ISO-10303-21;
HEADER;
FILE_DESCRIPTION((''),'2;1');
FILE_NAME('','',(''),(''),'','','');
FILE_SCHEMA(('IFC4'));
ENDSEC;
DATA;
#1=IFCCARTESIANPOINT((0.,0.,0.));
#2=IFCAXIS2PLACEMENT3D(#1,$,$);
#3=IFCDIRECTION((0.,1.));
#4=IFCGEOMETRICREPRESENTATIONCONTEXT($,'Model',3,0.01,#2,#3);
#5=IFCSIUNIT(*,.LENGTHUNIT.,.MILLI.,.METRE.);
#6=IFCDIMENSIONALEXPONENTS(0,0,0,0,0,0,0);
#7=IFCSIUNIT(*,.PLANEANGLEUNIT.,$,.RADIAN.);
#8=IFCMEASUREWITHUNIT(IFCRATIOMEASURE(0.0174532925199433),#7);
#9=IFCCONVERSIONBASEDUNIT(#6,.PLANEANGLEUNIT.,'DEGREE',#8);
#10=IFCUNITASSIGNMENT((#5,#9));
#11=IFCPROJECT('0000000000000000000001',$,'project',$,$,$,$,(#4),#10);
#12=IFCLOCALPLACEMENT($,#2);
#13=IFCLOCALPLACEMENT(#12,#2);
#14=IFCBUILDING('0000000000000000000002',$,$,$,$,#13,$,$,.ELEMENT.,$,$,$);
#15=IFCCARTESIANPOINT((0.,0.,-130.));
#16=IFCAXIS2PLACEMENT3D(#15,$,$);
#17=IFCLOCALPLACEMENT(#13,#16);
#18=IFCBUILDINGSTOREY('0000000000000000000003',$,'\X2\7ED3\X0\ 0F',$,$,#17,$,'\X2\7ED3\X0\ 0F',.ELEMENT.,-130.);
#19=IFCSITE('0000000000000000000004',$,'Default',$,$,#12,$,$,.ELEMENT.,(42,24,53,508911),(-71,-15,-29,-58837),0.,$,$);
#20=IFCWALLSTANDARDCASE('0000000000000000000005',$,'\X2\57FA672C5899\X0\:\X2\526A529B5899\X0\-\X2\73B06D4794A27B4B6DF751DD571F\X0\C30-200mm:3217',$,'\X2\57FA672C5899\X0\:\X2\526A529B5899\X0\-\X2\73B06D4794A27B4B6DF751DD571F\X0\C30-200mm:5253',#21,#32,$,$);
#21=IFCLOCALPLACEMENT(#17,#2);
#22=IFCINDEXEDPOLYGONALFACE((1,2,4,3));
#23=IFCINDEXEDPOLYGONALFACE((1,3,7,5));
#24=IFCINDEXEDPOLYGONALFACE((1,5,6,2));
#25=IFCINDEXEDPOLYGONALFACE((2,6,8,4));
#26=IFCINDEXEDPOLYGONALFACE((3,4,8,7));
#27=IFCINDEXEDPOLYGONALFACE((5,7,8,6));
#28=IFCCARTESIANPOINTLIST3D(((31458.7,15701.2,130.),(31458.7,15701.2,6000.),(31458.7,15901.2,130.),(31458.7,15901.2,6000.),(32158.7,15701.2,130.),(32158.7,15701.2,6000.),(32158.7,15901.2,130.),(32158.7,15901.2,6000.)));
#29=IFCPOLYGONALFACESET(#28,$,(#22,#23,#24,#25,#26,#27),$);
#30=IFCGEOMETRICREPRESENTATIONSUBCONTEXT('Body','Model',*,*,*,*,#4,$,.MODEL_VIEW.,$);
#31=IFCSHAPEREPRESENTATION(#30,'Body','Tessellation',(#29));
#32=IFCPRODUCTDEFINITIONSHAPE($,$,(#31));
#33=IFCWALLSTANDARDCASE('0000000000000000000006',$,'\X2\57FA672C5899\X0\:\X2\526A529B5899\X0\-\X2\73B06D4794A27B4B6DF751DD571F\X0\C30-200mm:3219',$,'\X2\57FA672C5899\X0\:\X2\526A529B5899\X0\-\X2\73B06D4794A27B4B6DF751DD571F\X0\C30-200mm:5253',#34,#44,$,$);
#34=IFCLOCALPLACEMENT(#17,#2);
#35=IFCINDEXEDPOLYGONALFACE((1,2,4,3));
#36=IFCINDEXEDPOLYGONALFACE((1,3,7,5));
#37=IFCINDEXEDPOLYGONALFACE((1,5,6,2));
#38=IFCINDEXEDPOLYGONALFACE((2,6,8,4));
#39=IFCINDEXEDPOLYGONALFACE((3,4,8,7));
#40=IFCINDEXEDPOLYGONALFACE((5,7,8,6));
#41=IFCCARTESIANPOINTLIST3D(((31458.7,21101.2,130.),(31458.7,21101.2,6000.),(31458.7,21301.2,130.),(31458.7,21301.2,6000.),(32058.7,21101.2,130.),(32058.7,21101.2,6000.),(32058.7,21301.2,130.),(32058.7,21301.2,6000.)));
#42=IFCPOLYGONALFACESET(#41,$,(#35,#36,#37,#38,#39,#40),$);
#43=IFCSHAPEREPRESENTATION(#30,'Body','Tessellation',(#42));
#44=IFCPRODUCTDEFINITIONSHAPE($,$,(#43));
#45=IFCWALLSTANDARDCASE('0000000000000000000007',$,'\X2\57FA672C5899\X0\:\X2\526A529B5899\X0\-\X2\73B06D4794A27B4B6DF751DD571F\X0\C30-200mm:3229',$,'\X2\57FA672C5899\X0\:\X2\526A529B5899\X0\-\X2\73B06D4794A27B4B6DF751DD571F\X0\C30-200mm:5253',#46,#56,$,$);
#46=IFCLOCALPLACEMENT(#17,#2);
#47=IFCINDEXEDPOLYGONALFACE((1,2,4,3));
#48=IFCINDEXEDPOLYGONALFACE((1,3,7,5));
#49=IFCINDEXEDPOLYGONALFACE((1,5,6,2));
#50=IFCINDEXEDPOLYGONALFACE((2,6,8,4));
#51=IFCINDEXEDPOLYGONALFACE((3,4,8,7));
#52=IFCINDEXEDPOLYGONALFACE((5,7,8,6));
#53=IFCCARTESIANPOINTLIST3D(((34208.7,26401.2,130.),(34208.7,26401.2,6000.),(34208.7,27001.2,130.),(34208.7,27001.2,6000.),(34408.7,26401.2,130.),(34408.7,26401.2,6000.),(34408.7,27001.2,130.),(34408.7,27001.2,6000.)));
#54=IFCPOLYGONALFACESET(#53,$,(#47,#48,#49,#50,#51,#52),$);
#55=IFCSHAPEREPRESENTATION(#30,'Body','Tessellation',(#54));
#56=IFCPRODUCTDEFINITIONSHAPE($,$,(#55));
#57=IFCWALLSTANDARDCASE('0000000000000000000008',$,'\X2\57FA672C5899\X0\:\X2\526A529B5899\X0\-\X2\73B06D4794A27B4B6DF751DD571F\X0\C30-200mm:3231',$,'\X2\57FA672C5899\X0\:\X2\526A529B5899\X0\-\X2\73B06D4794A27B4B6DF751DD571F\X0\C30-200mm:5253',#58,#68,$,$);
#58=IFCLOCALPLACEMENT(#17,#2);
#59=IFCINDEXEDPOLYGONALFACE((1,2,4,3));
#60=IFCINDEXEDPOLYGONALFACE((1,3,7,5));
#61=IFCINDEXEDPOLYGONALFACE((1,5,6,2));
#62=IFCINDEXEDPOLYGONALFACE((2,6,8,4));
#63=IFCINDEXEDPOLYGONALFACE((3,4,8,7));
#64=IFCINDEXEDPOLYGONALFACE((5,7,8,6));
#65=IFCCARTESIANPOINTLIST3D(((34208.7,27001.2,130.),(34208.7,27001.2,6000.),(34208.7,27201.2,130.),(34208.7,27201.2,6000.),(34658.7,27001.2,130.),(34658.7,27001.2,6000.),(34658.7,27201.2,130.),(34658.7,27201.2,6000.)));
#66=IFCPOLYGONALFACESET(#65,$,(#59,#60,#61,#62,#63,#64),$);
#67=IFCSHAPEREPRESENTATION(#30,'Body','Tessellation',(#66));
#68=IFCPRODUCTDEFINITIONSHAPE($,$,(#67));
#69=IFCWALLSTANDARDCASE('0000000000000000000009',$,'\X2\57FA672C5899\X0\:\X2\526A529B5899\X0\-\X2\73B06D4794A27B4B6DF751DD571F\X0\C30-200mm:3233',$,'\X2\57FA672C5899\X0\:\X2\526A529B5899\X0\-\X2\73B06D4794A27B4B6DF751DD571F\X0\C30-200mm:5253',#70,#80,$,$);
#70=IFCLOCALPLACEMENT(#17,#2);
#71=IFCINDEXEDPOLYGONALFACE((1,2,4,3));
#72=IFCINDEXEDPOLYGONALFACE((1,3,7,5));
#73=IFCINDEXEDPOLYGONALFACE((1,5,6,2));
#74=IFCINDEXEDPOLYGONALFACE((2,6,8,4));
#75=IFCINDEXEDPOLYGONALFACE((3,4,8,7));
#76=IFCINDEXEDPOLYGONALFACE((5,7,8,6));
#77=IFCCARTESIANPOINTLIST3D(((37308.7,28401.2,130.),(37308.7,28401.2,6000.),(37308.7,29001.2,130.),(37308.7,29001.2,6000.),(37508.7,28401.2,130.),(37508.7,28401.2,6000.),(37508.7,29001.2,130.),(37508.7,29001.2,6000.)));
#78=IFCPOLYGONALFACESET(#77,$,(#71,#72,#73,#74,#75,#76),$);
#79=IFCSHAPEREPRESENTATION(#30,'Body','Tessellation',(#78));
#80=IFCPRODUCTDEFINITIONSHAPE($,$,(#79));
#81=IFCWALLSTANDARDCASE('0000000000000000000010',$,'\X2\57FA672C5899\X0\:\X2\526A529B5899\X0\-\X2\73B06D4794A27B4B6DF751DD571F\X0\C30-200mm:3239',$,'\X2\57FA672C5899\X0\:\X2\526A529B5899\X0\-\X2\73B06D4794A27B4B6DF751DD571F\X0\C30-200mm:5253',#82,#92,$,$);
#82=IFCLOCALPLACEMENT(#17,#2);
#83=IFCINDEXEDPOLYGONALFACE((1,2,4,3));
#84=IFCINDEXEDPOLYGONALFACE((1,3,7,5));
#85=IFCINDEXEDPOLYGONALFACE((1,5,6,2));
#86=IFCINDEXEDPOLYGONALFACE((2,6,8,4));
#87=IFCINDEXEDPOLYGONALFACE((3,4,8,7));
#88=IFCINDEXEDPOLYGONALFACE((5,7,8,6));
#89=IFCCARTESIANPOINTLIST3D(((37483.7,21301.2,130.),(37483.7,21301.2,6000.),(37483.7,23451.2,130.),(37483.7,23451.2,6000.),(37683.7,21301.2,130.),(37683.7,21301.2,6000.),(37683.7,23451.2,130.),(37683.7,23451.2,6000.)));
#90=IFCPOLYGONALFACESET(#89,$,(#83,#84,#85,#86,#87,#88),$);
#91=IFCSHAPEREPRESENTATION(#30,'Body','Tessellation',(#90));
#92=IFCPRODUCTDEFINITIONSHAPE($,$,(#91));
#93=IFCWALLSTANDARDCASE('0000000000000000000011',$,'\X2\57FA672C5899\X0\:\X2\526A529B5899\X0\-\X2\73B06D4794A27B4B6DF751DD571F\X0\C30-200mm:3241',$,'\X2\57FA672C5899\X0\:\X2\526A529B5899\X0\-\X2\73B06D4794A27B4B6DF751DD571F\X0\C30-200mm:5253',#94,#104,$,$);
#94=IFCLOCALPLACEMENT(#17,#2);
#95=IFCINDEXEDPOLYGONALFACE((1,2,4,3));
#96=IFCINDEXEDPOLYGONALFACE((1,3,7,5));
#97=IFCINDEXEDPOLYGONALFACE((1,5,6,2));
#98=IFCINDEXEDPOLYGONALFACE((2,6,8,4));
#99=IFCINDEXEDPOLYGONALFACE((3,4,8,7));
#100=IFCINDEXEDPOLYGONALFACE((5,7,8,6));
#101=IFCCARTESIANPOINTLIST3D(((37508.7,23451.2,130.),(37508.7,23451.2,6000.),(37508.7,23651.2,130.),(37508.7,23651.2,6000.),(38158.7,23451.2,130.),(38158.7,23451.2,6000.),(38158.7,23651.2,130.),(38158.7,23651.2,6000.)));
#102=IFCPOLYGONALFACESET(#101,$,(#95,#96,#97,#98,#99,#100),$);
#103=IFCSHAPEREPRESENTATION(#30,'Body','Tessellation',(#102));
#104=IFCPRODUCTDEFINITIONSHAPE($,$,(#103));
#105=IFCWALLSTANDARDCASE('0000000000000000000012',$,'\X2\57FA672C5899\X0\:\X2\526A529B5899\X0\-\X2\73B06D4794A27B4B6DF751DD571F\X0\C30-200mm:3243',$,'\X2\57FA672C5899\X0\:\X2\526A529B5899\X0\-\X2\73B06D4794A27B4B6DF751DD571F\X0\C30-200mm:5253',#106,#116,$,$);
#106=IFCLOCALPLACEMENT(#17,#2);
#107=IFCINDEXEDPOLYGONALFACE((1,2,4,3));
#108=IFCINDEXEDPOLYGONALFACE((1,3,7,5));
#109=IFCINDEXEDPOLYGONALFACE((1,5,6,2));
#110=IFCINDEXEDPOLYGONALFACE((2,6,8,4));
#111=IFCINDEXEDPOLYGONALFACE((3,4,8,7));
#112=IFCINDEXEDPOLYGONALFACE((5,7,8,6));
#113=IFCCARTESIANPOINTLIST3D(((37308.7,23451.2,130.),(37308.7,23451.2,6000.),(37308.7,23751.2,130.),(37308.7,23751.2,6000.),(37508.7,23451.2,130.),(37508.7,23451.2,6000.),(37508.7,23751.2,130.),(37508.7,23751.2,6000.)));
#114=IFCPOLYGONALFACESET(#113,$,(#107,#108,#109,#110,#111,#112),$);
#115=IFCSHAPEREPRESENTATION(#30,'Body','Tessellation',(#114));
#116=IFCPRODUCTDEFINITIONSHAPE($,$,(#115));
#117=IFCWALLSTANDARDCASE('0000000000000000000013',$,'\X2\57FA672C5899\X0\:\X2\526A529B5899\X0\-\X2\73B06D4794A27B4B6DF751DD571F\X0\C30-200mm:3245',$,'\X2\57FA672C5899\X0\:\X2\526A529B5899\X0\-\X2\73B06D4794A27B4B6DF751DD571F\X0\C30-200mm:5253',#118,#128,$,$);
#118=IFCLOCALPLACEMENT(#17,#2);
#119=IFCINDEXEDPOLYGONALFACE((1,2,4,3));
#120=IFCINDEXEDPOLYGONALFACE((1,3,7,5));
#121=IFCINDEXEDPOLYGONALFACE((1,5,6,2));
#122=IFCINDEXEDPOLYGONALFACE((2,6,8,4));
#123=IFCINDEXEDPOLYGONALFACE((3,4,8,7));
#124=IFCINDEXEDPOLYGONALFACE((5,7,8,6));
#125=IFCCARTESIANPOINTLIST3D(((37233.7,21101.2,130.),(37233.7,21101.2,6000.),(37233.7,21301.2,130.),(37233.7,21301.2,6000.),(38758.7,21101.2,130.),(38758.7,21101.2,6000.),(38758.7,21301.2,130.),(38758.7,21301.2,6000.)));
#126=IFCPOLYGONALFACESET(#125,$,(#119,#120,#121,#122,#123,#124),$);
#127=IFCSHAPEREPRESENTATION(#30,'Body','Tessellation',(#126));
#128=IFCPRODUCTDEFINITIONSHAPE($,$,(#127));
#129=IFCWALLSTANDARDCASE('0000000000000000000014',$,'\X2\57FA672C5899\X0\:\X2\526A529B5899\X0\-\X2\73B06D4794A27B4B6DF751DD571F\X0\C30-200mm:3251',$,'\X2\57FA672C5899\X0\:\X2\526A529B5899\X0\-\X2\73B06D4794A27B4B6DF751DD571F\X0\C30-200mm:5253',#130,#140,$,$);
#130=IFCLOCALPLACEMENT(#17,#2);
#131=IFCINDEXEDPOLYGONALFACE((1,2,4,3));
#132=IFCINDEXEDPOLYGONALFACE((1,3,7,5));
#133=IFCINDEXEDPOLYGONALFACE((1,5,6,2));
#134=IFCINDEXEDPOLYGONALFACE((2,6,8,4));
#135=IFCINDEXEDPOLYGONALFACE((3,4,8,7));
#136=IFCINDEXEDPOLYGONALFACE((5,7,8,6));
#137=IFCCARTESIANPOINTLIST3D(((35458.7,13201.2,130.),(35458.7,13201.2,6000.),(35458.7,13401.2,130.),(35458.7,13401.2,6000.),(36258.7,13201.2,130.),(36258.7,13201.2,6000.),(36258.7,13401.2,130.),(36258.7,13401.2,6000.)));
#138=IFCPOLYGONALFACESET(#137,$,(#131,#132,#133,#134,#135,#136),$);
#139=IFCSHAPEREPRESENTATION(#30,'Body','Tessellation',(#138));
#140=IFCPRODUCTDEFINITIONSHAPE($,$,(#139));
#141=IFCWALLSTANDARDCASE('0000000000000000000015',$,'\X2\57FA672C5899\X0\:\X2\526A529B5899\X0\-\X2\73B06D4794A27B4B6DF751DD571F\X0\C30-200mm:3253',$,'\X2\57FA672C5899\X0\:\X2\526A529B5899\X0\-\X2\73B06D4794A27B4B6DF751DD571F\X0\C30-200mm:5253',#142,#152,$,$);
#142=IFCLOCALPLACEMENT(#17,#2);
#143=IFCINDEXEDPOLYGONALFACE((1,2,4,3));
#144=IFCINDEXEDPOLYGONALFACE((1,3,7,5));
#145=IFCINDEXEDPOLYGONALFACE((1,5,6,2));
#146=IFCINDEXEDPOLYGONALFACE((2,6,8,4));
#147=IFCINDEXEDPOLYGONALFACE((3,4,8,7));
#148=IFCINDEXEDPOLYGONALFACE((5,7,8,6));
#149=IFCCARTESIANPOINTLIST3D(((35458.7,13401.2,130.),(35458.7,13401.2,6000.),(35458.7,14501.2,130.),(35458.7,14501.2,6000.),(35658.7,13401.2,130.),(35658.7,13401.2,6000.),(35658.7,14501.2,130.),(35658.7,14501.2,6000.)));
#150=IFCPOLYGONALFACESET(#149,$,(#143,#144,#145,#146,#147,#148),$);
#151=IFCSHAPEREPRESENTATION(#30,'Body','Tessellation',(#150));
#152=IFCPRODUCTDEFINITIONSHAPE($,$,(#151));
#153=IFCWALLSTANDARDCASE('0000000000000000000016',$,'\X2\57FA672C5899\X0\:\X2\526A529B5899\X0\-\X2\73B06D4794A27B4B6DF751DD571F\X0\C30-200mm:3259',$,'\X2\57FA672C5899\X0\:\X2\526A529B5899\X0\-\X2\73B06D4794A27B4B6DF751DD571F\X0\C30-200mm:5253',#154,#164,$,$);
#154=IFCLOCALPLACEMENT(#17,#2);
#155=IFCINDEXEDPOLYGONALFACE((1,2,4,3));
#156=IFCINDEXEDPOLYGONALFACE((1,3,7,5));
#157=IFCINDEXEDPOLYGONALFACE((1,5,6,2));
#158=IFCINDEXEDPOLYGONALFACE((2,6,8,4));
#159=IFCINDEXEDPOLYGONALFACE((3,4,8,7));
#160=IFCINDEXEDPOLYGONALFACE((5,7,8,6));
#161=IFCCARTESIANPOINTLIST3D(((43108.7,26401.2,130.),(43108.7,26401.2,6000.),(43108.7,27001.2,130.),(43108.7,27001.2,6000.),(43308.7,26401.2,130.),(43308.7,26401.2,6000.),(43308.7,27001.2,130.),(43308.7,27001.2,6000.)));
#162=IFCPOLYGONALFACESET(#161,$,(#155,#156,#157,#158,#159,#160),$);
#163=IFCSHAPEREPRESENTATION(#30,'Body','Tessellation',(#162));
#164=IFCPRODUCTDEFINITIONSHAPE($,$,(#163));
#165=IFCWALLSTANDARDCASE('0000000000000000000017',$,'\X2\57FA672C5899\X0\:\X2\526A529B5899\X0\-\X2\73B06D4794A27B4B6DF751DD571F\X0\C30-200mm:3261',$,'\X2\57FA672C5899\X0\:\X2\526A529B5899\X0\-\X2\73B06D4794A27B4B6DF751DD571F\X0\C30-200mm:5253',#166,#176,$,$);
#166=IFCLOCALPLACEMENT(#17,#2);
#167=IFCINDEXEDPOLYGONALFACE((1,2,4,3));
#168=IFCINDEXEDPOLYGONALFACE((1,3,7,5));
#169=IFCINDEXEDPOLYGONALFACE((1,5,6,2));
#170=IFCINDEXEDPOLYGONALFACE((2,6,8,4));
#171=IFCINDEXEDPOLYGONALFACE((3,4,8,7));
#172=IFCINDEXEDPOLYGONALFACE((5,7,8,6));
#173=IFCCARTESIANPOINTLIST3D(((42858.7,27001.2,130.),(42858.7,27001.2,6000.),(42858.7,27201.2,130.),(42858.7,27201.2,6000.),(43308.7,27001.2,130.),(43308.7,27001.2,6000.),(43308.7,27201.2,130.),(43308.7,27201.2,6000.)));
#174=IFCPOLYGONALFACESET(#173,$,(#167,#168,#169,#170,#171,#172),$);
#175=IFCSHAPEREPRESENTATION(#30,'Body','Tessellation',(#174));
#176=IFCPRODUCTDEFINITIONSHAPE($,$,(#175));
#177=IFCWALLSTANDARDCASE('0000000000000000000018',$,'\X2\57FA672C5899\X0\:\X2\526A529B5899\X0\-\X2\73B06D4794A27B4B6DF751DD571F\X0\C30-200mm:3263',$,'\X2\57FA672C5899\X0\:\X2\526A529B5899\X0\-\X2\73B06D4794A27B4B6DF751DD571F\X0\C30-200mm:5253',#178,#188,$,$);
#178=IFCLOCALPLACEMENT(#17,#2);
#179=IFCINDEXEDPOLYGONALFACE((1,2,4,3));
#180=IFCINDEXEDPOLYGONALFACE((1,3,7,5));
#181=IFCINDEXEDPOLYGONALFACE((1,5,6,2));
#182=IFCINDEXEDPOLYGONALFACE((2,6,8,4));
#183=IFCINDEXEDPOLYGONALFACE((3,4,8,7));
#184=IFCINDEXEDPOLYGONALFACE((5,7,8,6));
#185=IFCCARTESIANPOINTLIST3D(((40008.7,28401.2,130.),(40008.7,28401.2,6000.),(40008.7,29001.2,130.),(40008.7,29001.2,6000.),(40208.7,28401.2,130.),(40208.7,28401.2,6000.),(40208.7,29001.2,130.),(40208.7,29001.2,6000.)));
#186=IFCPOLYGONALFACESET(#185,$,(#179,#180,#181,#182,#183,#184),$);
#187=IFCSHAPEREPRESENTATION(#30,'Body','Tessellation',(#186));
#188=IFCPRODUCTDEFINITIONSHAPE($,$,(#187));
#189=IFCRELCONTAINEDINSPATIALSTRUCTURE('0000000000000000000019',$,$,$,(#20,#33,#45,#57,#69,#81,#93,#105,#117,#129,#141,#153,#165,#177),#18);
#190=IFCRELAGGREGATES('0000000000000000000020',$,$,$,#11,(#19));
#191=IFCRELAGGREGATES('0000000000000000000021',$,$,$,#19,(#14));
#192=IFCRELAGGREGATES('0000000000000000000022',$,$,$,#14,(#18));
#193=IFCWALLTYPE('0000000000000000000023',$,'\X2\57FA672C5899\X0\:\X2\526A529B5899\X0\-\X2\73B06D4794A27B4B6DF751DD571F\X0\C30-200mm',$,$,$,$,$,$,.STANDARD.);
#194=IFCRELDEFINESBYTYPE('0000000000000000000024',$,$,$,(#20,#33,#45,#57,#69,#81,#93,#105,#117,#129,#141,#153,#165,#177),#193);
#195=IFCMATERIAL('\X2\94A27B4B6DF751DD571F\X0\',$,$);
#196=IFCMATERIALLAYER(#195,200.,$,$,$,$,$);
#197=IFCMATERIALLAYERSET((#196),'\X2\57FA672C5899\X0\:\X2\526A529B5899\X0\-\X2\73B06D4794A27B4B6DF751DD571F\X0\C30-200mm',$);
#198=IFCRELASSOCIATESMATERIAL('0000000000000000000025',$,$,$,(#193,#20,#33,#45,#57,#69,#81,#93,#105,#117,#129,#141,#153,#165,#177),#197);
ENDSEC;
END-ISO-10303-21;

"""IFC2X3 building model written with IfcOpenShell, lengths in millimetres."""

from ifc_helpers import new_model, entity, si_unit, converted_unit, direction, frame, frame_2d, origin, place, context, subcontext, project, spatial, rectangle, extrude, material, layer, layer_set, layer_usage, type_object, element, save


model = new_model("IFC2X3")

# Units and contexts
model_context = context("Model", 3, precision=0.01, world=origin(), true_north=direction((0.0, 1.0)))
body_context = subcontext(model_context, "Body", "Model", "MODEL_VIEW")
ifc_project = project(units=[si_unit("LENGTHUNIT", "METRE", prefix="MILLI"), converted_unit("PLANEANGLEUNIT", "DEGREE", entity("IfcRatioMeasure", 0.0174532925199433), si_unit("PLANEANGLEUNIT", "RADIAN"), dimensions=[0, 0, 0, 0, 0, 0, 0])], contexts=[model_context])

# Site, building, storey
site_placement = place(None, origin())
site = spatial("IfcSite", under=ifc_project, at=site_placement, Name="Default", CompositionType="ELEMENT", RefLatitude=(42, 24, 53, 508911), RefLongitude=(-71, -15, -29, -58837), RefElevation=0.0)
building_placement = place(site_placement, origin())
building = spatial("IfcBuilding", under=site, at=building_placement, CompositionType="ELEMENT")
storey_placement = place(building_placement, frame((0.0, 0.0, -130.0)))
storey = spatial("IfcBuildingStorey", under=building, at=storey_placement, Name="结 0F", LongName="结 0F", CompositionType="ELEMENT", Elevation=-130.0)

# Walls
ifc_material = material(Name="钢筋混凝土")
ifc_layer_1 = layer(ifc_material, 200.0)
ifc_layer_set_1 = layer_set([ifc_layer_1], Name="基本墙:剪力墙-现浇钢筋混凝土C30-200mm")
ifc_layer_usage_1 = layer_usage(ifc_layer_set_1, "AXIS2", "NEGATIVE", 100.0)
wall_type_1 = type_object("IfcWallType", Name="基本墙:剪力墙-现浇钢筋混凝土C30-200mm", PredefinedType="STANDARD", material=ifc_layer_set_1)
wall_1_placement = place(storey_placement, frame((31458.7, 15801.2, 130.0)))
element("IfcWallStandardCase", 1, at=wall_1_placement, inside=storey, type_object=wall_type_1, material=ifc_layer_usage_1, Name="基本墙:剪力墙-现浇钢筋混凝土C30-200mm:3217", ObjectType="基本墙:剪力墙-现浇钢筋混凝土C30-200mm:5253", context=body_context, shape_type="SweptSolid", body=[
    extrude(rectangle(XDim=700.0, YDim=200.0, at=frame_2d((350.0, 0.0), x_axis=(-1.0, 0.0))), origin(), (0.0, 0.0, 1.0), 5870.0),
])
ifc_layer_usage_2 = layer_usage(ifc_layer_set_1, "AXIS2", "NEGATIVE", 100.0)
wall_2_placement = place(storey_placement, frame((32058.7, 21201.2, 130.0), z_axis=(0.0, 0.0, 1.0), x_axis=(-1.0, 0.0, 0.0)))
element("IfcWallStandardCase", 2, at=wall_2_placement, inside=storey, type_object=wall_type_1, material=ifc_layer_usage_2, Name="基本墙:剪力墙-现浇钢筋混凝土C30-200mm:3219", ObjectType="基本墙:剪力墙-现浇钢筋混凝土C30-200mm:5253", context=body_context, shape_type="SweptSolid", body=[
    extrude(rectangle(XDim=600.0, YDim=200.0, at=frame_2d((300.0, 0.0), x_axis=(-1.0, 0.0))), origin(), (0.0, 0.0, 1.0), 5870.0),
])
ifc_layer_usage_3 = layer_usage(ifc_layer_set_1, "AXIS2", "NEGATIVE", 100.0)
wall_3_placement = place(storey_placement, frame((34308.7, 26401.2, 130.0), z_axis=(0.0, 0.0, 1.0), x_axis=(0.0, 1.0, 0.0)))
element("IfcWallStandardCase", 3, at=wall_3_placement, inside=storey, type_object=wall_type_1, material=ifc_layer_usage_3, Name="基本墙:剪力墙-现浇钢筋混凝土C30-200mm:3229", ObjectType="基本墙:剪力墙-现浇钢筋混凝土C30-200mm:5253", context=body_context, shape_type="SweptSolid", body=[
    extrude(rectangle(XDim=600.0, YDim=200.0, at=frame_2d((300.0, 0.0), x_axis=(-1.0, 0.0))), origin(), (0.0, 0.0, 1.0), 5870.0),
])
ifc_layer_usage_4 = layer_usage(ifc_layer_set_1, "AXIS2", "NEGATIVE", 100.0)
wall_4_placement = place(storey_placement, frame((34208.7, 27101.2, 130.0)))
element("IfcWallStandardCase", 4, at=wall_4_placement, inside=storey, type_object=wall_type_1, material=ifc_layer_usage_4, Name="基本墙:剪力墙-现浇钢筋混凝土C30-200mm:3231", ObjectType="基本墙:剪力墙-现浇钢筋混凝土C30-200mm:5253", context=body_context, shape_type="SweptSolid", body=[
    extrude(rectangle(XDim=450.0, YDim=200.0, at=frame_2d((225.0, 0.0), x_axis=(-1.0, 0.0))), origin(), (0.0, 0.0, 1.0), 5870.0),
])
ifc_layer_usage_5 = layer_usage(ifc_layer_set_1, "AXIS2", "NEGATIVE", 100.0)
wall_5_placement = place(storey_placement, frame((37408.7, 28401.2, 130.0), z_axis=(0.0, 0.0, 1.0), x_axis=(0.0, 1.0, 0.0)))
element("IfcWallStandardCase", 5, at=wall_5_placement, inside=storey, type_object=wall_type_1, material=ifc_layer_usage_5, Name="基本墙:剪力墙-现浇钢筋混凝土C30-200mm:3233", ObjectType="基本墙:剪力墙-现浇钢筋混凝土C30-200mm:5253", context=body_context, shape_type="SweptSolid", body=[
    extrude(rectangle(XDim=600.0, YDim=200.0, at=frame_2d((300.0, 0.0), x_axis=(-1.0, 0.0))), origin(), (0.0, 0.0, 1.0), 5870.0),
])
ifc_layer_usage_6 = layer_usage(ifc_layer_set_1, "AXIS2", "NEGATIVE", 100.0)
wall_6_placement = place(storey_placement, frame((37583.7, 21301.2, 130.0), z_axis=(0.0, 0.0, 1.0), x_axis=(0.0, 1.0, 0.0)))
element("IfcWallStandardCase", 6, at=wall_6_placement, inside=storey, type_object=wall_type_1, material=ifc_layer_usage_6, Name="基本墙:剪力墙-现浇钢筋混凝土C30-200mm:3239", ObjectType="基本墙:剪力墙-现浇钢筋混凝土C30-200mm:5253", context=body_context, shape_type="SweptSolid", body=[
    extrude(rectangle(XDim=2150.0, YDim=200.0, at=frame_2d((1075.0, 0.0), x_axis=(-1.0, 0.0))), origin(), (0.0, 0.0, 1.0), 5870.0),
])
ifc_layer_usage_7 = layer_usage(ifc_layer_set_1, "AXIS2", "NEGATIVE", 100.0)
wall_7_placement = place(storey_placement, frame((38158.7, 23551.2, 130.0), z_axis=(0.0, 0.0, 1.0), x_axis=(-1.0, 0.0, 0.0)))
element("IfcWallStandardCase", 7, at=wall_7_placement, inside=storey, type_object=wall_type_1, material=ifc_layer_usage_7, Name="基本墙:剪力墙-现浇钢筋混凝土C30-200mm:3241", ObjectType="基本墙:剪力墙-现浇钢筋混凝土C30-200mm:5253", context=body_context, shape_type="SweptSolid", body=[
    extrude(rectangle(XDim=650.0, YDim=200.0, at=frame_2d((325.0, 0.0), x_axis=(-1.0, 0.0))), origin(), (0.0, 0.0, 1.0), 5870.0),
])
ifc_layer_usage_8 = layer_usage(ifc_layer_set_1, "AXIS2", "NEGATIVE", 100.0)
wall_8_placement = place(storey_placement, frame((37408.7, 23451.2, 130.0), z_axis=(0.0, 0.0, 1.0), x_axis=(0.0, 1.0, 0.0)))
element("IfcWallStandardCase", 8, at=wall_8_placement, inside=storey, type_object=wall_type_1, material=ifc_layer_usage_8, Name="基本墙:剪力墙-现浇钢筋混凝土C30-200mm:3243", ObjectType="基本墙:剪力墙-现浇钢筋混凝土C30-200mm:5253", context=body_context, shape_type="SweptSolid", body=[
    extrude(rectangle(XDim=300.0, YDim=200.0, at=frame_2d((150.0, 0.0), x_axis=(-1.0, 0.0))), origin(), (0.0, 0.0, 1.0), 5870.0),
])
ifc_layer_usage_9 = layer_usage(ifc_layer_set_1, "AXIS2", "NEGATIVE", 100.0)
wall_9_placement = place(storey_placement, frame((37233.7, 21201.2, 130.0)))
element("IfcWallStandardCase", 9, at=wall_9_placement, inside=storey, type_object=wall_type_1, material=ifc_layer_usage_9, Name="基本墙:剪力墙-现浇钢筋混凝土C30-200mm:3245", ObjectType="基本墙:剪力墙-现浇钢筋混凝土C30-200mm:5253", context=body_context, shape_type="SweptSolid", body=[
    extrude(rectangle(XDim=1525.0, YDim=200.0, at=frame_2d((762.5, 0.0), x_axis=(-1.0, 0.0))), origin(), (0.0, 0.0, 1.0), 5870.0),
])
ifc_layer_usage_10 = layer_usage(ifc_layer_set_1, "AXIS2", "NEGATIVE", 100.0)
wall_10_placement = place(storey_placement, frame((36258.7, 13301.2, 130.0), z_axis=(0.0, 0.0, 1.0), x_axis=(-1.0, 0.0, 0.0)))
element("IfcWallStandardCase", 10, at=wall_10_placement, inside=storey, type_object=wall_type_1, material=ifc_layer_usage_10, Name="基本墙:剪力墙-现浇钢筋混凝土C30-200mm:3251", ObjectType="基本墙:剪力墙-现浇钢筋混凝土C30-200mm:5253", context=body_context, shape_type="SweptSolid", body=[
    extrude(rectangle(XDim=800.0, YDim=200.0, at=frame_2d((400.0, 0.0), x_axis=(-1.0, 0.0))), origin(), (0.0, 0.0, 1.0), 5870.0),
])
ifc_layer_usage_11 = layer_usage(ifc_layer_set_1, "AXIS2", "NEGATIVE", 100.0)
wall_11_placement = place(storey_placement, frame((35558.7, 13401.2, 130.0), z_axis=(0.0, 0.0, 1.0), x_axis=(0.0, 1.0, 0.0)))
element("IfcWallStandardCase", 11, at=wall_11_placement, inside=storey, type_object=wall_type_1, material=ifc_layer_usage_11, Name="基本墙:剪力墙-现浇钢筋混凝土C30-200mm:3253", ObjectType="基本墙:剪力墙-现浇钢筋混凝土C30-200mm:5253", context=body_context, shape_type="SweptSolid", body=[
    extrude(rectangle(XDim=1100.0, YDim=200.0, at=frame_2d((550.0, 0.0), x_axis=(-1.0, 0.0))), origin(), (0.0, 0.0, 1.0), 5870.0),
])
ifc_layer_usage_12 = layer_usage(ifc_layer_set_1, "AXIS2", "POSITIVE", -100.0)
wall_12_placement = place(storey_placement, frame((43208.7, 26401.2, 130.0), z_axis=(0.0, 0.0, 1.0), x_axis=(0.0, 1.0, 0.0)))
element("IfcWallStandardCase", 12, at=wall_12_placement, inside=storey, type_object=wall_type_1, material=ifc_layer_usage_12, Name="基本墙:剪力墙-现浇钢筋混凝土C30-200mm:3259", ObjectType="基本墙:剪力墙-现浇钢筋混凝土C30-200mm:5253", context=body_context, shape_type="SweptSolid", body=[
    extrude(rectangle(XDim=600.0, YDim=200.0, at=frame_2d((300.0, 0.0), x_axis=(-1.0, 0.0))), origin(), (0.0, 0.0, 1.0), 5870.0),
])
ifc_layer_usage_13 = layer_usage(ifc_layer_set_1, "AXIS2", "POSITIVE", -100.0)
wall_13_placement = place(storey_placement, frame((43308.7, 27101.2, 130.0), z_axis=(0.0, 0.0, 1.0), x_axis=(-1.0, 0.0, 0.0)))
element("IfcWallStandardCase", 13, at=wall_13_placement, inside=storey, type_object=wall_type_1, material=ifc_layer_usage_13, Name="基本墙:剪力墙-现浇钢筋混凝土C30-200mm:3261", ObjectType="基本墙:剪力墙-现浇钢筋混凝土C30-200mm:5253", context=body_context, shape_type="SweptSolid", body=[
    extrude(rectangle(XDim=450.0, YDim=200.0, at=frame_2d((225.0, 0.0), x_axis=(-1.0, 0.0))), origin(), (0.0, 0.0, 1.0), 5870.0),
])
ifc_layer_usage_14 = layer_usage(ifc_layer_set_1, "AXIS2", "POSITIVE", -100.0)
wall_14_placement = place(storey_placement, frame((40108.7, 28401.2, 130.0), z_axis=(0.0, 0.0, 1.0), x_axis=(0.0, 1.0, 0.0)))
element("IfcWallStandardCase", 14, at=wall_14_placement, inside=storey, type_object=wall_type_1, material=ifc_layer_usage_14, Name="基本墙:剪力墙-现浇钢筋混凝土C30-200mm:3263", ObjectType="基本墙:剪力墙-现浇钢筋混凝土C30-200mm:5253", context=body_context, shape_type="SweptSolid", body=[
    extrude(rectangle(XDim=600.0, YDim=200.0, at=frame_2d((300.0, 0.0), x_axis=(-1.0, 0.0))), origin(), (0.0, 0.0, 1.0), 5870.0),
])

save(model, "model.ifc")
